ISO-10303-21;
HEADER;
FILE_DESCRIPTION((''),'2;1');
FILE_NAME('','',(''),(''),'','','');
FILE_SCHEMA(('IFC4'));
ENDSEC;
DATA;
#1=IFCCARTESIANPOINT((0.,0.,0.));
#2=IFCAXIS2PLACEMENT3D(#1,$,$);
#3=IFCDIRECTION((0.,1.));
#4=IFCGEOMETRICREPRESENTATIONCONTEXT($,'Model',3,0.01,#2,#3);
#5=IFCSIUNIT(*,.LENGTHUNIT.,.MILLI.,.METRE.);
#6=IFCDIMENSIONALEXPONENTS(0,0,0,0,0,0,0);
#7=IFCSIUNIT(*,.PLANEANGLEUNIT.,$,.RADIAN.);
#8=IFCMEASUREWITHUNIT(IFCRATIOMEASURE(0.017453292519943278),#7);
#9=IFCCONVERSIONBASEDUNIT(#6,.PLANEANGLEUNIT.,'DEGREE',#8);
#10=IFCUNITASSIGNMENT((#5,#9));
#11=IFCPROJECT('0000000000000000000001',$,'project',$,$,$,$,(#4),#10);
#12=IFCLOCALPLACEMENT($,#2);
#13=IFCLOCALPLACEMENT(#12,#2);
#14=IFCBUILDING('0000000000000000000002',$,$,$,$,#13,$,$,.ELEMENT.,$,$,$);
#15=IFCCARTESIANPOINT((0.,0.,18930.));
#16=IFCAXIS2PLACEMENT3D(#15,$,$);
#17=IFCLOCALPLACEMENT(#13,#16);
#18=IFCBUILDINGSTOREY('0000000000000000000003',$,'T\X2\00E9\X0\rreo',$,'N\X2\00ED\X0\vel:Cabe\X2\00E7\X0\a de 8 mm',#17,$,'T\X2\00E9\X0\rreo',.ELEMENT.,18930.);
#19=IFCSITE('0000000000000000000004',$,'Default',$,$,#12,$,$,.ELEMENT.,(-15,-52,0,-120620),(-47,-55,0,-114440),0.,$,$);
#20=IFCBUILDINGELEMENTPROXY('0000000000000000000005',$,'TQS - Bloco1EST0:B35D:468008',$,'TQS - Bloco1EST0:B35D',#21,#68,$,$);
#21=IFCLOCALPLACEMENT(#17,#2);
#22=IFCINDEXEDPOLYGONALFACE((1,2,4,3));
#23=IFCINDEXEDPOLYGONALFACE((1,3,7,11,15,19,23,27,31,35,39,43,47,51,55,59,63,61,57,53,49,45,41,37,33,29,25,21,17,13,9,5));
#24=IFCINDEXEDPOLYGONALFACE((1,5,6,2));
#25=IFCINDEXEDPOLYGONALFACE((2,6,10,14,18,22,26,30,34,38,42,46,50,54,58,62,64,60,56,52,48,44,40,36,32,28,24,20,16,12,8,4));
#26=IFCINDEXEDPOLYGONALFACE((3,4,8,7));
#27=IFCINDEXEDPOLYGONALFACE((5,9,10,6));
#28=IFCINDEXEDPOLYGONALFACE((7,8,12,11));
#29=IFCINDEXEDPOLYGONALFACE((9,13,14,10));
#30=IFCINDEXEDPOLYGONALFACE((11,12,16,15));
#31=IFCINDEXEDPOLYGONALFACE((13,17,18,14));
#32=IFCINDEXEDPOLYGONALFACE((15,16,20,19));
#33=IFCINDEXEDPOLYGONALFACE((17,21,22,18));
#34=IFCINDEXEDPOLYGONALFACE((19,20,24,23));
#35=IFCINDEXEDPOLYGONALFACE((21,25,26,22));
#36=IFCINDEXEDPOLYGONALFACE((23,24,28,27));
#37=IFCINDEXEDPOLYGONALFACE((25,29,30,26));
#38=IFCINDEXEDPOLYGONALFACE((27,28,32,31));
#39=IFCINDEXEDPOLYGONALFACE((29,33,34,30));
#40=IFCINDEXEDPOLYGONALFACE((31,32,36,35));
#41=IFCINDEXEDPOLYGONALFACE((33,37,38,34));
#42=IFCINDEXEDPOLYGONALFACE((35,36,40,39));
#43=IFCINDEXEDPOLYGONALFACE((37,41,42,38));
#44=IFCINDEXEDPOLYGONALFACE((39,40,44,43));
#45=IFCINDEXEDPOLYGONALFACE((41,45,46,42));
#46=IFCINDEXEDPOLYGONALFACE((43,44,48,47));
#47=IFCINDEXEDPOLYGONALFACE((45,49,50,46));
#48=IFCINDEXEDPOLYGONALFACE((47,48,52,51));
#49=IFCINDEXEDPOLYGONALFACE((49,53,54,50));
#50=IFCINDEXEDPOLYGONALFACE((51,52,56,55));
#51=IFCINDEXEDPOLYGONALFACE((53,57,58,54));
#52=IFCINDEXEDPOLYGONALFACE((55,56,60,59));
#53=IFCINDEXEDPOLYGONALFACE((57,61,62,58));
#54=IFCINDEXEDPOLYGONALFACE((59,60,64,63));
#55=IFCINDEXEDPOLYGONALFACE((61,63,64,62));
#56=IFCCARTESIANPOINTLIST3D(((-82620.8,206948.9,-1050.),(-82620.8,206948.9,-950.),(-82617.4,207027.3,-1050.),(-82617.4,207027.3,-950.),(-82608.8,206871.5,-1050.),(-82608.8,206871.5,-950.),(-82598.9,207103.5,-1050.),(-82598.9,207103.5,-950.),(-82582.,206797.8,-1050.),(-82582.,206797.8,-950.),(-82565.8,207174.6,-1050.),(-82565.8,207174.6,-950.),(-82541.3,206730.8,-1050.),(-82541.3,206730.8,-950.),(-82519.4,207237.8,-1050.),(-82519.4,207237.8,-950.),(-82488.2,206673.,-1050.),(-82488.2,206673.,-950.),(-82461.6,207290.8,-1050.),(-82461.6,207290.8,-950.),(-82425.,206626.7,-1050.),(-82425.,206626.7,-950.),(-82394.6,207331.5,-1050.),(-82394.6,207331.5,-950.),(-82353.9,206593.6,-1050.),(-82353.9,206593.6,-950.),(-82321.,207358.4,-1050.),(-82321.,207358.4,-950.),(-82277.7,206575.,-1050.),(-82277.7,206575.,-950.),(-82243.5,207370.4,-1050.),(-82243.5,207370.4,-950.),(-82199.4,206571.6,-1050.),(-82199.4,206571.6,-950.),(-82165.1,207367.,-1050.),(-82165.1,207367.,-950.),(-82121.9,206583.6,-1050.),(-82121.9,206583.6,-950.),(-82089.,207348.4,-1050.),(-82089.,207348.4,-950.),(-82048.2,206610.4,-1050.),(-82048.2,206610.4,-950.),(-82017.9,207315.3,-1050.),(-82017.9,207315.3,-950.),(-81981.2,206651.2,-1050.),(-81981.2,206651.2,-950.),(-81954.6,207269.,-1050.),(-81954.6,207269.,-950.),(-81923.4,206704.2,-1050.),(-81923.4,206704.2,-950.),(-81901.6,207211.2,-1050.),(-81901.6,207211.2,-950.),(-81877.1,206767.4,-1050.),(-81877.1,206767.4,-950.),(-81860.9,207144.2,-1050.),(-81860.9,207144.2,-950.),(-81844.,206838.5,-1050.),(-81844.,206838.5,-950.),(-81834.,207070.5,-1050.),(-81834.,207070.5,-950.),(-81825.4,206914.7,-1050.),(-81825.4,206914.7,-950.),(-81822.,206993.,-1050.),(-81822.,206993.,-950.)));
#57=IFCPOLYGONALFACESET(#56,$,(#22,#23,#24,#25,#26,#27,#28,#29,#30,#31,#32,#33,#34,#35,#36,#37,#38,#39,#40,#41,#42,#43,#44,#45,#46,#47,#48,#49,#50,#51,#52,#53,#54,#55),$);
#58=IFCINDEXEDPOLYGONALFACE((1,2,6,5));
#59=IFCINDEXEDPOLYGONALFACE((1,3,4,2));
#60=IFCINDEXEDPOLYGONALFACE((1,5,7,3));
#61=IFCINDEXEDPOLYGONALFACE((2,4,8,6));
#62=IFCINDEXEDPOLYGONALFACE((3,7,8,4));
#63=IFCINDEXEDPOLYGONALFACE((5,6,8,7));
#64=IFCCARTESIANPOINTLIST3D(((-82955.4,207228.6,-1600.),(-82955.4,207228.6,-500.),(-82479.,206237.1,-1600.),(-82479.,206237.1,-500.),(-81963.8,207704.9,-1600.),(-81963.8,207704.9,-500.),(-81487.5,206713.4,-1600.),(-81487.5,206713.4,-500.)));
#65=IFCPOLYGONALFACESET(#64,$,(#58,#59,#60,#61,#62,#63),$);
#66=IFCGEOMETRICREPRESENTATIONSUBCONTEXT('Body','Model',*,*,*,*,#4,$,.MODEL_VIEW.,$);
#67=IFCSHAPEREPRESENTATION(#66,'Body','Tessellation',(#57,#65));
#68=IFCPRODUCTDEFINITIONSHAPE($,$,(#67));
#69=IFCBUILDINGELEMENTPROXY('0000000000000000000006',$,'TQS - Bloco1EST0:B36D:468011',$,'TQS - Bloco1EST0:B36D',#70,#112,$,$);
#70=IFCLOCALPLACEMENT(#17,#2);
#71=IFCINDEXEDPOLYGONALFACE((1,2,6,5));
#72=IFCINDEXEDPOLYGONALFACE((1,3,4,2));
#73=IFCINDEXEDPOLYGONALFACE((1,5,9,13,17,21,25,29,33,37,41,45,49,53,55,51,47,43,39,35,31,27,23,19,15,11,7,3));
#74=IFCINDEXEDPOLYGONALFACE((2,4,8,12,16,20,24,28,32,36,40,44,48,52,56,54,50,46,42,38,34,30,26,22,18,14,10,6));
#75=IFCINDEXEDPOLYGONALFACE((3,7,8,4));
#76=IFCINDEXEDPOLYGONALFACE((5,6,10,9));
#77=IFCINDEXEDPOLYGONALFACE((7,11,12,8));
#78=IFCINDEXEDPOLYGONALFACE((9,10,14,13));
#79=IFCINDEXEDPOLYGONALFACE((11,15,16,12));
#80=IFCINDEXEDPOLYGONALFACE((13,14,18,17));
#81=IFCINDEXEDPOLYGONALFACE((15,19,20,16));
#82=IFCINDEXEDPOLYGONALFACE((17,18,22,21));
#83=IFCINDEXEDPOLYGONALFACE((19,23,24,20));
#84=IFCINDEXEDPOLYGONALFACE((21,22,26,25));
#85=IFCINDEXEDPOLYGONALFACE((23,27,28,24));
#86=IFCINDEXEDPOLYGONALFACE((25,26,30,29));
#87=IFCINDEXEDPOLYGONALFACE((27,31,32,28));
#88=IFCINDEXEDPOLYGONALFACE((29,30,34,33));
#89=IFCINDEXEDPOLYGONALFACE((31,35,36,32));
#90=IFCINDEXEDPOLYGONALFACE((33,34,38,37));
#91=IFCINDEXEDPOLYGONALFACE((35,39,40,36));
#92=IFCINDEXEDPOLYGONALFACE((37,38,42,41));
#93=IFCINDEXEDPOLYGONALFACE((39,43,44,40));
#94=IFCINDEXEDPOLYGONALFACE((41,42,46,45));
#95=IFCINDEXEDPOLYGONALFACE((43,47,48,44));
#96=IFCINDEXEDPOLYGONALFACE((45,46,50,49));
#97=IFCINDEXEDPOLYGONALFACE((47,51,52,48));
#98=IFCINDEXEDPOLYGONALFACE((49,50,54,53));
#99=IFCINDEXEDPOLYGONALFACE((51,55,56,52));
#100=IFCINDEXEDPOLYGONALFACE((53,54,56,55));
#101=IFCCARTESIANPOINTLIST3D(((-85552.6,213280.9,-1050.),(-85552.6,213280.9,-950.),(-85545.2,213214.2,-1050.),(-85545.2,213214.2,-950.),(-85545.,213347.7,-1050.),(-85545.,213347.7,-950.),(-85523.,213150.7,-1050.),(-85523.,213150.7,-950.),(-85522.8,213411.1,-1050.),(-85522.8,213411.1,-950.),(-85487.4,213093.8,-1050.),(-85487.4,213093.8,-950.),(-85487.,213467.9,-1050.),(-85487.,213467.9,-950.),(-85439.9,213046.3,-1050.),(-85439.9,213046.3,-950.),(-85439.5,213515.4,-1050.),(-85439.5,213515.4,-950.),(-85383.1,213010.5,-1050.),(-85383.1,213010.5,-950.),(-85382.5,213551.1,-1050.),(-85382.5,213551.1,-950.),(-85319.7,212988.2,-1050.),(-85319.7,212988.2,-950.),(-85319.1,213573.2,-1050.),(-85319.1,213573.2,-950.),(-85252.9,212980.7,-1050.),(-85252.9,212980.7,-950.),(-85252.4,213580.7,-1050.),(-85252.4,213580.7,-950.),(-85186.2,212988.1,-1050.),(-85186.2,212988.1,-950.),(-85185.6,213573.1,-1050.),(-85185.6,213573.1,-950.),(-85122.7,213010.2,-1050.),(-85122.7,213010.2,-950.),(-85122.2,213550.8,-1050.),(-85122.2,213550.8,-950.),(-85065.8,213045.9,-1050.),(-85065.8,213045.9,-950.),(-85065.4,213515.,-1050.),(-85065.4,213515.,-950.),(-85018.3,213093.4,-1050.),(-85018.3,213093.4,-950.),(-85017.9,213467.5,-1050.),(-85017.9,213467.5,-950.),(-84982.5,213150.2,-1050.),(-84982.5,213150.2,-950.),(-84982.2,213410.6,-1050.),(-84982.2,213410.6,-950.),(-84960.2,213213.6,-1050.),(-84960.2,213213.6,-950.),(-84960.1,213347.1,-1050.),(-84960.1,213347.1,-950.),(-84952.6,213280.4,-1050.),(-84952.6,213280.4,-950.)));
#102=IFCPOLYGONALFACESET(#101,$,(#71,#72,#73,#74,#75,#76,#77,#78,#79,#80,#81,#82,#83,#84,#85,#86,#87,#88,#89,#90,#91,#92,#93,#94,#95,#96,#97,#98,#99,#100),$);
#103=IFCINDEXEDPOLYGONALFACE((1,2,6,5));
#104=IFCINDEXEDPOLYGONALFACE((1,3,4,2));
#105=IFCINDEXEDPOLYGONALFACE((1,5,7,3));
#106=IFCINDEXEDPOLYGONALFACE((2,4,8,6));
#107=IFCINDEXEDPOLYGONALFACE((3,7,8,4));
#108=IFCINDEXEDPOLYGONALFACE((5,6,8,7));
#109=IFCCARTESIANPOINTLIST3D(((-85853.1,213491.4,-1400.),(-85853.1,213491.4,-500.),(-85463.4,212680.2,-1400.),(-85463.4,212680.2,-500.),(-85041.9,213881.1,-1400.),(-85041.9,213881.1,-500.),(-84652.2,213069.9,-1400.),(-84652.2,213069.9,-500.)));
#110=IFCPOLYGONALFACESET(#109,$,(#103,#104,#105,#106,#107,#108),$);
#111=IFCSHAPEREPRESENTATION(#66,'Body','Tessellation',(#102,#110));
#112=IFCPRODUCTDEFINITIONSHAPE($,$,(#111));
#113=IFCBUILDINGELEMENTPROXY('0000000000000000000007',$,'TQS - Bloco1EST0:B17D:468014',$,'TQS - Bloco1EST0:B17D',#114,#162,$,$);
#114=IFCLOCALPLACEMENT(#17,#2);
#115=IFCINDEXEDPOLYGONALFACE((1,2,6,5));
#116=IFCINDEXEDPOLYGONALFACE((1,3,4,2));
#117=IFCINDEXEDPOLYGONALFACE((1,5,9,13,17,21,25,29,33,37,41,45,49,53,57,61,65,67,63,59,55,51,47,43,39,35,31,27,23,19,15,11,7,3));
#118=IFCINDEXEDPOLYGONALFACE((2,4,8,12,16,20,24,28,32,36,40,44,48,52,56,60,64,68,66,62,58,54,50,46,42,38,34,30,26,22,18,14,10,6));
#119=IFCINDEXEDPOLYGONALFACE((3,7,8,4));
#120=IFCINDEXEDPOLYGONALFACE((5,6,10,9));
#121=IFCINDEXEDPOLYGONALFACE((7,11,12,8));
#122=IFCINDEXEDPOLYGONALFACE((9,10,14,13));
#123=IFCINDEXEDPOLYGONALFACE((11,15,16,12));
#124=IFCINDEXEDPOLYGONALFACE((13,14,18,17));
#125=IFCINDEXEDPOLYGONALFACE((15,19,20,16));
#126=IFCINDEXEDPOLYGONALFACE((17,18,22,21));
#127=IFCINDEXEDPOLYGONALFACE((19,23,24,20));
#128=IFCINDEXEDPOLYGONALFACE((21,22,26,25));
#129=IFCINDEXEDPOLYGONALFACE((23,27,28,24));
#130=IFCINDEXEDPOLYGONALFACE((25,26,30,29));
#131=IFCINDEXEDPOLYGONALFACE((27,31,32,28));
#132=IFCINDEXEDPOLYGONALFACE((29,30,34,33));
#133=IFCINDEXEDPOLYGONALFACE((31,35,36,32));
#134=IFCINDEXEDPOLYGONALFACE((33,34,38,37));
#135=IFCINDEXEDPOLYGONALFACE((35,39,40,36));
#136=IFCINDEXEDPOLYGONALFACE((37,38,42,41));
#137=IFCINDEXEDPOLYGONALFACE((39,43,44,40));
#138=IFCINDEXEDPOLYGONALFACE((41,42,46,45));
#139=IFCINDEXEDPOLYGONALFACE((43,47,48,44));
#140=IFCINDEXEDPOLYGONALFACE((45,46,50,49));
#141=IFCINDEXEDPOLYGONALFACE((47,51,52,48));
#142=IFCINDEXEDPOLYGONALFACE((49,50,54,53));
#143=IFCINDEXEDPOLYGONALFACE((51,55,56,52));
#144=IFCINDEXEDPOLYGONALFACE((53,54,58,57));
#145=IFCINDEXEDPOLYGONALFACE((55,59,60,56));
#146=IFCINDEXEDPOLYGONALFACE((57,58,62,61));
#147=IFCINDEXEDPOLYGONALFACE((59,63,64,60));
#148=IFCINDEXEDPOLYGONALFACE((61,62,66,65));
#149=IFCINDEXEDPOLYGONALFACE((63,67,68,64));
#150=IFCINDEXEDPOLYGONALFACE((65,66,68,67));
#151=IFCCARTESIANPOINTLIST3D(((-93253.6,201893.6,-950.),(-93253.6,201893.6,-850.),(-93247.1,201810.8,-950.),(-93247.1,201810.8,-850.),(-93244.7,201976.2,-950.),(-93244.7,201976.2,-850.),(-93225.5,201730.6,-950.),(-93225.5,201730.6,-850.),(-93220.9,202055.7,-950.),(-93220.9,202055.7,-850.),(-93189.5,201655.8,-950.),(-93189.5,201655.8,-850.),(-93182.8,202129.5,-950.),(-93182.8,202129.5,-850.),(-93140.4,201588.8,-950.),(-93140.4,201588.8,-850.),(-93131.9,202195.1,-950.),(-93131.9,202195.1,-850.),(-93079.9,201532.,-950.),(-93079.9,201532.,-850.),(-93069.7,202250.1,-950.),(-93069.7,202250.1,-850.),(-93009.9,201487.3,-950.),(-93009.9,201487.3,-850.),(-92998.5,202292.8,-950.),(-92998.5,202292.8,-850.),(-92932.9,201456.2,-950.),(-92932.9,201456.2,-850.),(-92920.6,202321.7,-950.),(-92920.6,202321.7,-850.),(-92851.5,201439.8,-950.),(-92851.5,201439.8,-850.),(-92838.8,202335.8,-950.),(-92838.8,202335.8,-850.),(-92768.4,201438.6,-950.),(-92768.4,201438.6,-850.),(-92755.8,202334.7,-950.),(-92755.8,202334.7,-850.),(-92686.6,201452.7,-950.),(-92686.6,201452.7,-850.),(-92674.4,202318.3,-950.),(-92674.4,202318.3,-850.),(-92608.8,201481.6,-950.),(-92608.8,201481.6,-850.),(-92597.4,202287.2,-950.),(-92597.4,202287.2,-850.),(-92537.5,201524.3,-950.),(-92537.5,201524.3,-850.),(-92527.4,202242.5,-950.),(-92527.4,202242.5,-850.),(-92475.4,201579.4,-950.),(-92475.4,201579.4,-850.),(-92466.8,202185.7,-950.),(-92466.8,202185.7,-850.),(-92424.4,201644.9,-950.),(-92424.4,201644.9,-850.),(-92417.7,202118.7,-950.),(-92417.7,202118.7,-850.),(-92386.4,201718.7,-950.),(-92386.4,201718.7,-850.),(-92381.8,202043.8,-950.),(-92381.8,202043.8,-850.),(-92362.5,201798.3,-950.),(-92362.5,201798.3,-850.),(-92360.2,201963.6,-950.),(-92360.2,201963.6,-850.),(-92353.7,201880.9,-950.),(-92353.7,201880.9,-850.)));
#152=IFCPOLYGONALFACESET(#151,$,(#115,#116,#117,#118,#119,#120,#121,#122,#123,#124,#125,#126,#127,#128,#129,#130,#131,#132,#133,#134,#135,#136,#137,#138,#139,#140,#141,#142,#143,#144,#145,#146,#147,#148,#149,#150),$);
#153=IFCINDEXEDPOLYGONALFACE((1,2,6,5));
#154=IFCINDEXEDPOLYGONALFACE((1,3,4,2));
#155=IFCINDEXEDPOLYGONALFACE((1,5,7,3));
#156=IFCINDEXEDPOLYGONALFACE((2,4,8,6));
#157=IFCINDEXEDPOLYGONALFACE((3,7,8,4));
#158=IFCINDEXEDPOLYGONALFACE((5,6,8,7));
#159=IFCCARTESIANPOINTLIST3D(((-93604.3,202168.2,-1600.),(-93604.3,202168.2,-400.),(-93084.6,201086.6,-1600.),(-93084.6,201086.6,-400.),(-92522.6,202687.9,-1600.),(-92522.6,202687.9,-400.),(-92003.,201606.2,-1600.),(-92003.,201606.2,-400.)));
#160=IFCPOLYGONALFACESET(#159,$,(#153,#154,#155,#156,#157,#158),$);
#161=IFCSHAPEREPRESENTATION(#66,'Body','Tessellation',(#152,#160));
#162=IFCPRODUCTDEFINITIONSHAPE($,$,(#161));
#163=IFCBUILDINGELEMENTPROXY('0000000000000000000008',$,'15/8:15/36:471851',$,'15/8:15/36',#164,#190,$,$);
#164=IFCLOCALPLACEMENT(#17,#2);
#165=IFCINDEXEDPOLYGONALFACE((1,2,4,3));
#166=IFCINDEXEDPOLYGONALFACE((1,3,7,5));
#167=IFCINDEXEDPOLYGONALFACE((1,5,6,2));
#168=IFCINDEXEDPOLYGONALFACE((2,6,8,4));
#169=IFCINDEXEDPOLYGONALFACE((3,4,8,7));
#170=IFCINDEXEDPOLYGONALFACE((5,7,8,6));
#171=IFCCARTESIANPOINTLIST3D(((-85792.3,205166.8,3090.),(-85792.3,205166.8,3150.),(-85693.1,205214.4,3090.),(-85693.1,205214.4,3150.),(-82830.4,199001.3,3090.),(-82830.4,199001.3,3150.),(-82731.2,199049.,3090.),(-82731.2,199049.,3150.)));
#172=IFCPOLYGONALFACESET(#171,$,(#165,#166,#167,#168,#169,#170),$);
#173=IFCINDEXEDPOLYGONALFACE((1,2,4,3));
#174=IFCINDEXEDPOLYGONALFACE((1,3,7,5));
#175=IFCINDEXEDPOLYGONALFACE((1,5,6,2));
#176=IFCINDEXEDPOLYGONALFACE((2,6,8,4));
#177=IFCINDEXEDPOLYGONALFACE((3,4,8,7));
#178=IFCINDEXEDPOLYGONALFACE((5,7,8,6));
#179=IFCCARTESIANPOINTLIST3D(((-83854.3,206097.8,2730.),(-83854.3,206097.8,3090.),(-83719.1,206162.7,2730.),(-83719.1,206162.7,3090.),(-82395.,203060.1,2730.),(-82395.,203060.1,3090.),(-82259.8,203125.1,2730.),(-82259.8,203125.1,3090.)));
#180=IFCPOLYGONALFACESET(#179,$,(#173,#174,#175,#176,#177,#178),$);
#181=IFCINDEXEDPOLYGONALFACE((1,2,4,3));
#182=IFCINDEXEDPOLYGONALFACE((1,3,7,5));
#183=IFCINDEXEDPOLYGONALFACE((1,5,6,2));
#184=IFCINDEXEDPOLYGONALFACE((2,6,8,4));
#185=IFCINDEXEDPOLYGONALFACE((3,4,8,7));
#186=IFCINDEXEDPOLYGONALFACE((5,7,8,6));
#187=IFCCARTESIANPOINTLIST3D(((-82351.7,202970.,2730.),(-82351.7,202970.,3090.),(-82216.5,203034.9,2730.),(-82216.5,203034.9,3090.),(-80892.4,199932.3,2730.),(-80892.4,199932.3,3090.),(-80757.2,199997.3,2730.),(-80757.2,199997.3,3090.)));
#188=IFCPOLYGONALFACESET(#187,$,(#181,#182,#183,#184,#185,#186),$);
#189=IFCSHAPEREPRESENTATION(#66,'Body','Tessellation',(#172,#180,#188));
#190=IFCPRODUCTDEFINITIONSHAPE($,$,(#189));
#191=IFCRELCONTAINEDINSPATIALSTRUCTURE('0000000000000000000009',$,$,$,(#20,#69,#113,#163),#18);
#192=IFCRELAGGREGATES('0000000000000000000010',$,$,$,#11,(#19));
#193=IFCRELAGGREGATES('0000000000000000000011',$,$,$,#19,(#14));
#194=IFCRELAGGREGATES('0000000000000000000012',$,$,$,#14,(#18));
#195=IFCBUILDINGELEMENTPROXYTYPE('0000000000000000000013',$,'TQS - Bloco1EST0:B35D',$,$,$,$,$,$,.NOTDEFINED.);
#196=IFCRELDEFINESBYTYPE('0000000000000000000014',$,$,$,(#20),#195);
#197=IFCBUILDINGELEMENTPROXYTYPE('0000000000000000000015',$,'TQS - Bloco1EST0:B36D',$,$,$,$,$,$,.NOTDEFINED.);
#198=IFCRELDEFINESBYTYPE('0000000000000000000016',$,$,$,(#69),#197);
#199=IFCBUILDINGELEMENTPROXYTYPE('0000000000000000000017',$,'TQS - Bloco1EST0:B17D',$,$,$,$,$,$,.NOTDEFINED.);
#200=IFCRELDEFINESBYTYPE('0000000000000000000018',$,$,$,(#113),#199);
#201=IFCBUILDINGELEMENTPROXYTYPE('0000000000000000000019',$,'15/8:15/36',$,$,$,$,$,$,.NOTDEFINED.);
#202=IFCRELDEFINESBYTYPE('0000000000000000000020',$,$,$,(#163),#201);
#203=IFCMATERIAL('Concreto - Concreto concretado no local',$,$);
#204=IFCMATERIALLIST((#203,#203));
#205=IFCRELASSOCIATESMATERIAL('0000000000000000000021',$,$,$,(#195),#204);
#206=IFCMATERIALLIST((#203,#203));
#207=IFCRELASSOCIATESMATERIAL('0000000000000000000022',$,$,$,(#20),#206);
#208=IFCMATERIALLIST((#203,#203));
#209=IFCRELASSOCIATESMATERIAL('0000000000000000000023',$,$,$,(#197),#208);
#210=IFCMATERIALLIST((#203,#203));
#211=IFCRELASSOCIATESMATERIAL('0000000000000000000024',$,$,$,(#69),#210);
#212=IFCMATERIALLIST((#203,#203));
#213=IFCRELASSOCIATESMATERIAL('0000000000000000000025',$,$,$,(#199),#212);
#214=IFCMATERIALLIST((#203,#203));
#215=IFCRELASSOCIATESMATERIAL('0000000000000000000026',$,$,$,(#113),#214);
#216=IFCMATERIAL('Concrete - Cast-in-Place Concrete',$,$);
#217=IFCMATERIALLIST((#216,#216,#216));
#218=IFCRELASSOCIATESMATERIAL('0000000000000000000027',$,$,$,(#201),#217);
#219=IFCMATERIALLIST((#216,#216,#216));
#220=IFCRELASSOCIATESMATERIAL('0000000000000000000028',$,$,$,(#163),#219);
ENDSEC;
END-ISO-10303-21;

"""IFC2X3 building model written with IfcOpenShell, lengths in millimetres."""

from ifc_helpers import new_model, entity, si_unit, converted_unit, direction, frame, frame_2d, origin, origin_2d_with_axis, place, context, subcontext, project, spatial, rectangle, circle, extrude, source, transform, mapped, material, material_list, type_object, type_shapes, element, save


model = new_model("IFC2X3")

# Units and contexts
model_context = context("Model", 3, precision=0.01, world=origin(), true_north=direction((0.0, 1.0)))
body_context = subcontext(model_context, "Body", "Model", "MODEL_VIEW")
ifc_project = project(units=[si_unit("LENGTHUNIT", "METRE", prefix="MILLI"), converted_unit("PLANEANGLEUNIT", "DEGREE", entity("IfcRatioMeasure", 0.017453292519943278), si_unit("PLANEANGLEUNIT", "RADIAN"), dimensions=[0, 0, 0, 0, 0, 0, 0])], contexts=[model_context])

# Site, building, storey
site_placement = place(None, origin())
site = spatial("IfcSite", under=ifc_project, at=site_placement, Name="Default", CompositionType="ELEMENT", RefLatitude=(-15, -52, 0, -120620), RefLongitude=(-47, -55, 0, -114440), RefElevation=0.0)
building_placement = place(site_placement, origin())
building = spatial("IfcBuilding", under=site, at=building_placement, CompositionType="ELEMENT")
storey_placement = place(building_placement, frame((0.0, 0.0, 18930.0)))
storey = spatial("IfcBuildingStorey", under=building, at=storey_placement, Name="Térreo", ObjectType="Nível:Cabeça de 8 mm", LongName="Térreo", CompositionType="ELEMENT", Elevation=18930.0)

# Building element proxies
ifc_material_1 = material(Name="Concreto - Concreto concretado no local")
ifc_material_list_1 = material_list([ifc_material_1, ifc_material_1])
ifc_material_list_2 = material_list([ifc_material_1, ifc_material_1])
building_element_proxy_type_1 = type_object("IfcBuildingElementProxyType", Name="TQS - Bloco1EST0:B35D", PredefinedType="NOTDEFINED", material=ifc_material_list_2)
shared_shape_1 = source(origin(), body_context, "Body", "SweptSolid", [
    extrude(circle(Radius=400.0, at=frame_2d((0.0, 0.0), x_axis=(1.0, 0.0))), frame((0.0, 0.0, -550.0)), (0.0, 0.0, 1.0), 100.0),
    extrude(rectangle(XDim=1100.0, YDim=1100.0, at=origin_2d_with_axis()), frame((0.0, 0.0, -1100.0), z_axis=(0.0, 0.0, 1.0), x_axis=(-1.0, 0.0, 0.0)), (0.0, 0.0, 1.0), 1100.0),
])
type_shapes(building_element_proxy_type_1, [shared_shape_1])
proxy_1_placement = place(storey_placement, frame((-82221.4, 206971.0, -500.0), z_axis=(0.0, 0.0, 1.0), x_axis=(-0.43303, 0.90138, 0.0)))
element("IfcBuildingElementProxy", 1, at=proxy_1_placement, inside=storey, type_object=building_element_proxy_type_1, material=ifc_material_list_1, Name="TQS - Bloco1EST0:B35D:468008", ObjectType="TQS - Bloco1EST0:B35D", context=body_context, shape_type="MappedRepresentation", body=[
    mapped(shared_shape_1, transform((0.0, 0.0, 0.0), scale=1.0)),
])
ifc_material_list_3 = material_list([ifc_material_1, ifc_material_1])
ifc_material_list_4 = material_list([ifc_material_1, ifc_material_1])
building_element_proxy_type_2 = type_object("IfcBuildingElementProxyType", Name="TQS - Bloco1EST0:B36D", PredefinedType="NOTDEFINED", material=ifc_material_list_4)
shared_shape_2 = source(origin(), body_context, "Body", "SweptSolid", [
    extrude(circle(Radius=300.0, at=frame_2d((0.0, 0.0), x_axis=(1.0, 0.0))), frame((0.0, 0.0, -550.0)), (0.0, 0.0, 1.0), 100.0),
    extrude(rectangle(XDim=900.0, YDim=900.0, at=origin_2d_with_axis()), frame((0.0, 0.0, -900.0), z_axis=(0.0, 0.0, 1.0), x_axis=(-1.0, 0.0, 0.0)), (0.0, 0.0, 1.0), 900.0),
])
type_shapes(building_element_proxy_type_2, [shared_shape_2])
proxy_2_placement = place(storey_placement, frame((-85252.6, 213280.7, -500.0), z_axis=(0.0, 0.0, 1.0), x_axis=(-0.43303, 0.90138, 0.0)))
element("IfcBuildingElementProxy", 2, at=proxy_2_placement, inside=storey, type_object=building_element_proxy_type_2, material=ifc_material_list_3, Name="TQS - Bloco1EST0:B36D:468011", ObjectType="TQS - Bloco1EST0:B36D", context=body_context, shape_type="MappedRepresentation", body=[
    mapped(shared_shape_2, transform((0.0, 0.0, 0.0), scale=1.0)),
])
ifc_material_list_5 = material_list([ifc_material_1, ifc_material_1])
ifc_material_list_6 = material_list([ifc_material_1, ifc_material_1])
building_element_proxy_type_3 = type_object("IfcBuildingElementProxyType", Name="TQS - Bloco1EST0:B17D", PredefinedType="NOTDEFINED", material=ifc_material_list_6)
shared_shape_3 = source(origin(), body_context, "Body", "SweptSolid", [
    extrude(circle(Radius=450.0, at=frame_2d((0.0, 0.0), x_axis=(1.0, 0.0))), frame((0.0, 0.0, -550.0)), (0.0, 0.0, 1.0), 100.0),
    extrude(rectangle(XDim=1200.0, YDim=1200.0, at=origin_2d_with_axis()), frame((0.0, 0.0, -1200.0), z_axis=(0.0, 0.0, 1.0), x_axis=(-1.0, 0.0, 0.0)), (0.0, 0.0, 1.0), 1200.0),
])
type_shapes(building_element_proxy_type_3, [shared_shape_3])
proxy_3_placement = place(storey_placement, frame((-92803.6, 201887.2, -400.0), z_axis=(0.0, 0.0, 1.0), x_axis=(-0.43303, 0.90138, 0.0)))
element("IfcBuildingElementProxy", 3, at=proxy_3_placement, inside=storey, type_object=building_element_proxy_type_3, material=ifc_material_list_5, Name="TQS - Bloco1EST0:B17D:468014", ObjectType="TQS - Bloco1EST0:B17D", context=body_context, shape_type="MappedRepresentation", body=[
    mapped(shared_shape_3, transform((0.0, 0.0, 0.0), scale=1.0)),
])
ifc_material_2 = material(Name="Concrete - Cast-in-Place Concrete")
ifc_material_list_7 = material_list([ifc_material_2, ifc_material_2, ifc_material_2])
ifc_material_list_8 = material_list([ifc_material_2, ifc_material_2, ifc_material_2])
building_element_proxy_type_4 = type_object("IfcBuildingElementProxyType", Name="15/8:15/36", PredefinedType="NOTDEFINED", material=ifc_material_list_8)
shared_shape_4 = source(origin(), body_context, "Body", "SweptSolid", [
    extrude(rectangle(XDim=110.0, YDim=6840.0, at=frame_2d((0.0, 0.0), x_axis=(1.0, 0.0))), frame((1530.5, 3106.5, 360.0), z_axis=(0.0, 0.0, 1.0), x_axis=(0.90138, 0.43303, 0.0)), (0.0, 0.0, 1.0), 60.0),
    extrude(rectangle(XDim=3370.0, YDim=150.0, at=frame_2d((0.0, 0.0), x_axis=(1.0, 0.0))), frame((2735.2, 5610.1, 0.0), z_axis=(0.0, 0.0, 1.0), x_axis=(0.43303, -0.90138, 0.0)), (0.0, 0.0, 1.0), 360.0),
    extrude(rectangle(XDim=3370.0, YDim=150.0, at=frame_2d((0.0, 0.0), x_axis=(1.0, 0.0))), frame((4237.8, 2482.3, 0.0), z_axis=(0.0, 0.0, 1.0), x_axis=(0.43303, -0.90138, 0.0)), (0.0, 0.0, 1.0), 360.0),
])
type_shapes(building_element_proxy_type_4, [shared_shape_4])
proxy_4_placement = place(storey_placement, frame((-85792.3, 199001.3, 2730.0)))
element("IfcBuildingElementProxy", 4, at=proxy_4_placement, inside=storey, type_object=building_element_proxy_type_4, material=ifc_material_list_7, Name="15/8:15/36:471851", ObjectType="15/8:15/36", context=body_context, shape_type="MappedRepresentation", body=[
    mapped(shared_shape_4, transform((0.0, 0.0, 0.0), scale=1.0)),
])

save(model, "model.ifc")
